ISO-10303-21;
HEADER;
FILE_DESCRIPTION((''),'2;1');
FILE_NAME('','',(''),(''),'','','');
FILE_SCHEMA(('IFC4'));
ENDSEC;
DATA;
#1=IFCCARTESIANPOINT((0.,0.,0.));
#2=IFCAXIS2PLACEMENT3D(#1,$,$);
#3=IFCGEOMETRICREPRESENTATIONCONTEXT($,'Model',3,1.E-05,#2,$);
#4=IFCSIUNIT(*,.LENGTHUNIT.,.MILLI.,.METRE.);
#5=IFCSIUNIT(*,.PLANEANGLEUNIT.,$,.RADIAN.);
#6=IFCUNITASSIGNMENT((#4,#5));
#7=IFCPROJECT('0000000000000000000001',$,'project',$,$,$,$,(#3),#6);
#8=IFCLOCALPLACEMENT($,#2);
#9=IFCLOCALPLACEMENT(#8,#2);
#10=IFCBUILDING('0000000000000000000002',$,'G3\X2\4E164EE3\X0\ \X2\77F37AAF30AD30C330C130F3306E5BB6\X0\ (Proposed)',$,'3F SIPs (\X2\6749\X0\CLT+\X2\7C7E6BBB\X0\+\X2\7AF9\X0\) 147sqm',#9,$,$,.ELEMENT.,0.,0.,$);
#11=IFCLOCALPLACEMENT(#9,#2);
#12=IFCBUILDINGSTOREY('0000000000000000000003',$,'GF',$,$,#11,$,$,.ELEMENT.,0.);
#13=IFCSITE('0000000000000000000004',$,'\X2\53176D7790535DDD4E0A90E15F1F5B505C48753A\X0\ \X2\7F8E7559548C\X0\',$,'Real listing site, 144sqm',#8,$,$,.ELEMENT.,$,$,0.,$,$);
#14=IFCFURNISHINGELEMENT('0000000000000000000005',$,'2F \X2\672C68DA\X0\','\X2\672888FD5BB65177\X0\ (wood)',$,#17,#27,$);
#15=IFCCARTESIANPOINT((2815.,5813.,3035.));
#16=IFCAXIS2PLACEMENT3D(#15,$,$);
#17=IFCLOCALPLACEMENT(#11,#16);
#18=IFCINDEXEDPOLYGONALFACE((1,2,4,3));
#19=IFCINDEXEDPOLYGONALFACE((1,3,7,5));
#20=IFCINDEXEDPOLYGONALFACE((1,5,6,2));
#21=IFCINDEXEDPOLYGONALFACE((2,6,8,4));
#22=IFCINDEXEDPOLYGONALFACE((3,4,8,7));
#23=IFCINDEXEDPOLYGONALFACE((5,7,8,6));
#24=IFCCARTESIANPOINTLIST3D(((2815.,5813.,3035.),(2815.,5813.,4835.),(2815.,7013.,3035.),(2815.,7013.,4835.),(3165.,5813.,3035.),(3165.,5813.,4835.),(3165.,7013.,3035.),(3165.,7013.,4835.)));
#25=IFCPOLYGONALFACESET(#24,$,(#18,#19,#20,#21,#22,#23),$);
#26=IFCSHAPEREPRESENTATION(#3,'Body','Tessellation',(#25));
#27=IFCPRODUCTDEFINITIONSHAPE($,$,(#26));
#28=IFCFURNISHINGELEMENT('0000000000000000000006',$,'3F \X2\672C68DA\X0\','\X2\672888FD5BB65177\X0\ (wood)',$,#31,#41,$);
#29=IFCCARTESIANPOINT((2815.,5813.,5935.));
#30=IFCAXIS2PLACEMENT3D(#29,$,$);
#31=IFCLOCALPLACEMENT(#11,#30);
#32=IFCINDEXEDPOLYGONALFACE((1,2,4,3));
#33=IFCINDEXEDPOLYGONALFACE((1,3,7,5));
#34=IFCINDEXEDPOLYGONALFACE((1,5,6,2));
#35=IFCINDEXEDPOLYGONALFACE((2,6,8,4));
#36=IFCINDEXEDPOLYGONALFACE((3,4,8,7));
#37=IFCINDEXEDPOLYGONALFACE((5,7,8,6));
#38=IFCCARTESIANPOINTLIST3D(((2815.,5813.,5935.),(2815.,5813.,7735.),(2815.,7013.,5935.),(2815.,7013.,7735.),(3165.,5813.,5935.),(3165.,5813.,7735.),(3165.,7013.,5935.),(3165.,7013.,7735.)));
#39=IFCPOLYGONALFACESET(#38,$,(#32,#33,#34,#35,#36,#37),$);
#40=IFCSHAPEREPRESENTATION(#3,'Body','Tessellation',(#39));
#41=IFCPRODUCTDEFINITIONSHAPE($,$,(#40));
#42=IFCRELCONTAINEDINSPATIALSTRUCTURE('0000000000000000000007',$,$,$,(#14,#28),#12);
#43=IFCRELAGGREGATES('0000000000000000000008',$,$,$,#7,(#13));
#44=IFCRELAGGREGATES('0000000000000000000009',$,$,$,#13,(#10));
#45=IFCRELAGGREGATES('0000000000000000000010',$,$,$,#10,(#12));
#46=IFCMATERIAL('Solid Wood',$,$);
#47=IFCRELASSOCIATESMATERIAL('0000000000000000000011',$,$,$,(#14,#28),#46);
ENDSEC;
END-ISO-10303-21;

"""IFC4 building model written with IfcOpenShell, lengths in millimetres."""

from ifc_helpers import new_model, si_unit, frame, frame_2d, origin, place, context, project, spatial, rectangle, extrude, material, element, save


model = new_model("IFC4")

# Units and contexts
model_context = context("Model", 3, precision=1e-05, world=origin())
ifc_project = project(units=[si_unit("LENGTHUNIT", "METRE", prefix="MILLI"), si_unit("PLANEANGLEUNIT", "RADIAN")], contexts=[model_context])

# Site, building, storey
site_placement = place(None, origin())
site = spatial("IfcSite", under=ifc_project, at=site_placement, Name="北海道川上郡弟子屈町 美留和", ObjectType="Real listing site, 144sqm", CompositionType="ELEMENT", RefElevation=0.0)
building_placement = place(site_placement, origin())
building = spatial("IfcBuilding", under=site, at=building_placement, Name="G3世代 石窯キッチンの家 (Proposed)", ObjectType="3F SIPs (杉CLT+籾殻+竹) 147sqm", CompositionType="ELEMENT", ElevationOfRefHeight=0.0, ElevationOfTerrain=0.0)
storey_placement = place(building_placement, origin())
storey = spatial("IfcBuildingStorey", under=building, at=storey_placement, Name="GF", CompositionType="ELEMENT", Elevation=0.0)

# Shared definitions
ifc_material_1 = material(Name="Solid Wood")

# Furnishing elements
furnishing_1_placement = place(storey_placement, frame((2815.0, 5813.0, 3035.0)))
element("IfcFurnishingElement", 1, at=furnishing_1_placement, inside=storey, material=ifc_material_1, Name="2F 本棚", Description="木製家具 (wood)", context=model_context, shape_type="SweptSolid", body=[
    extrude(rectangle(XDim=350.0, YDim=1200.0, at=frame_2d((175.0, 600.0))), frame((2815.0, 5813.0, 3035.0)), (0.0, 0.0, 1.0), 1800.0),
])
furnishing_2_placement = place(storey_placement, frame((2815.0, 5813.0, 5935.0)))
element("IfcFurnishingElement", 2, at=furnishing_2_placement, inside=storey, material=ifc_material_1, Name="3F 本棚", Description="木製家具 (wood)", context=model_context, shape_type="SweptSolid", body=[
    extrude(rectangle(XDim=350.0, YDim=1200.0, at=frame_2d((175.0, 600.0))), frame((2815.0, 5813.0, 5935.0)), (0.0, 0.0, 1.0), 1800.0),
])

save(model, "model.ifc")
